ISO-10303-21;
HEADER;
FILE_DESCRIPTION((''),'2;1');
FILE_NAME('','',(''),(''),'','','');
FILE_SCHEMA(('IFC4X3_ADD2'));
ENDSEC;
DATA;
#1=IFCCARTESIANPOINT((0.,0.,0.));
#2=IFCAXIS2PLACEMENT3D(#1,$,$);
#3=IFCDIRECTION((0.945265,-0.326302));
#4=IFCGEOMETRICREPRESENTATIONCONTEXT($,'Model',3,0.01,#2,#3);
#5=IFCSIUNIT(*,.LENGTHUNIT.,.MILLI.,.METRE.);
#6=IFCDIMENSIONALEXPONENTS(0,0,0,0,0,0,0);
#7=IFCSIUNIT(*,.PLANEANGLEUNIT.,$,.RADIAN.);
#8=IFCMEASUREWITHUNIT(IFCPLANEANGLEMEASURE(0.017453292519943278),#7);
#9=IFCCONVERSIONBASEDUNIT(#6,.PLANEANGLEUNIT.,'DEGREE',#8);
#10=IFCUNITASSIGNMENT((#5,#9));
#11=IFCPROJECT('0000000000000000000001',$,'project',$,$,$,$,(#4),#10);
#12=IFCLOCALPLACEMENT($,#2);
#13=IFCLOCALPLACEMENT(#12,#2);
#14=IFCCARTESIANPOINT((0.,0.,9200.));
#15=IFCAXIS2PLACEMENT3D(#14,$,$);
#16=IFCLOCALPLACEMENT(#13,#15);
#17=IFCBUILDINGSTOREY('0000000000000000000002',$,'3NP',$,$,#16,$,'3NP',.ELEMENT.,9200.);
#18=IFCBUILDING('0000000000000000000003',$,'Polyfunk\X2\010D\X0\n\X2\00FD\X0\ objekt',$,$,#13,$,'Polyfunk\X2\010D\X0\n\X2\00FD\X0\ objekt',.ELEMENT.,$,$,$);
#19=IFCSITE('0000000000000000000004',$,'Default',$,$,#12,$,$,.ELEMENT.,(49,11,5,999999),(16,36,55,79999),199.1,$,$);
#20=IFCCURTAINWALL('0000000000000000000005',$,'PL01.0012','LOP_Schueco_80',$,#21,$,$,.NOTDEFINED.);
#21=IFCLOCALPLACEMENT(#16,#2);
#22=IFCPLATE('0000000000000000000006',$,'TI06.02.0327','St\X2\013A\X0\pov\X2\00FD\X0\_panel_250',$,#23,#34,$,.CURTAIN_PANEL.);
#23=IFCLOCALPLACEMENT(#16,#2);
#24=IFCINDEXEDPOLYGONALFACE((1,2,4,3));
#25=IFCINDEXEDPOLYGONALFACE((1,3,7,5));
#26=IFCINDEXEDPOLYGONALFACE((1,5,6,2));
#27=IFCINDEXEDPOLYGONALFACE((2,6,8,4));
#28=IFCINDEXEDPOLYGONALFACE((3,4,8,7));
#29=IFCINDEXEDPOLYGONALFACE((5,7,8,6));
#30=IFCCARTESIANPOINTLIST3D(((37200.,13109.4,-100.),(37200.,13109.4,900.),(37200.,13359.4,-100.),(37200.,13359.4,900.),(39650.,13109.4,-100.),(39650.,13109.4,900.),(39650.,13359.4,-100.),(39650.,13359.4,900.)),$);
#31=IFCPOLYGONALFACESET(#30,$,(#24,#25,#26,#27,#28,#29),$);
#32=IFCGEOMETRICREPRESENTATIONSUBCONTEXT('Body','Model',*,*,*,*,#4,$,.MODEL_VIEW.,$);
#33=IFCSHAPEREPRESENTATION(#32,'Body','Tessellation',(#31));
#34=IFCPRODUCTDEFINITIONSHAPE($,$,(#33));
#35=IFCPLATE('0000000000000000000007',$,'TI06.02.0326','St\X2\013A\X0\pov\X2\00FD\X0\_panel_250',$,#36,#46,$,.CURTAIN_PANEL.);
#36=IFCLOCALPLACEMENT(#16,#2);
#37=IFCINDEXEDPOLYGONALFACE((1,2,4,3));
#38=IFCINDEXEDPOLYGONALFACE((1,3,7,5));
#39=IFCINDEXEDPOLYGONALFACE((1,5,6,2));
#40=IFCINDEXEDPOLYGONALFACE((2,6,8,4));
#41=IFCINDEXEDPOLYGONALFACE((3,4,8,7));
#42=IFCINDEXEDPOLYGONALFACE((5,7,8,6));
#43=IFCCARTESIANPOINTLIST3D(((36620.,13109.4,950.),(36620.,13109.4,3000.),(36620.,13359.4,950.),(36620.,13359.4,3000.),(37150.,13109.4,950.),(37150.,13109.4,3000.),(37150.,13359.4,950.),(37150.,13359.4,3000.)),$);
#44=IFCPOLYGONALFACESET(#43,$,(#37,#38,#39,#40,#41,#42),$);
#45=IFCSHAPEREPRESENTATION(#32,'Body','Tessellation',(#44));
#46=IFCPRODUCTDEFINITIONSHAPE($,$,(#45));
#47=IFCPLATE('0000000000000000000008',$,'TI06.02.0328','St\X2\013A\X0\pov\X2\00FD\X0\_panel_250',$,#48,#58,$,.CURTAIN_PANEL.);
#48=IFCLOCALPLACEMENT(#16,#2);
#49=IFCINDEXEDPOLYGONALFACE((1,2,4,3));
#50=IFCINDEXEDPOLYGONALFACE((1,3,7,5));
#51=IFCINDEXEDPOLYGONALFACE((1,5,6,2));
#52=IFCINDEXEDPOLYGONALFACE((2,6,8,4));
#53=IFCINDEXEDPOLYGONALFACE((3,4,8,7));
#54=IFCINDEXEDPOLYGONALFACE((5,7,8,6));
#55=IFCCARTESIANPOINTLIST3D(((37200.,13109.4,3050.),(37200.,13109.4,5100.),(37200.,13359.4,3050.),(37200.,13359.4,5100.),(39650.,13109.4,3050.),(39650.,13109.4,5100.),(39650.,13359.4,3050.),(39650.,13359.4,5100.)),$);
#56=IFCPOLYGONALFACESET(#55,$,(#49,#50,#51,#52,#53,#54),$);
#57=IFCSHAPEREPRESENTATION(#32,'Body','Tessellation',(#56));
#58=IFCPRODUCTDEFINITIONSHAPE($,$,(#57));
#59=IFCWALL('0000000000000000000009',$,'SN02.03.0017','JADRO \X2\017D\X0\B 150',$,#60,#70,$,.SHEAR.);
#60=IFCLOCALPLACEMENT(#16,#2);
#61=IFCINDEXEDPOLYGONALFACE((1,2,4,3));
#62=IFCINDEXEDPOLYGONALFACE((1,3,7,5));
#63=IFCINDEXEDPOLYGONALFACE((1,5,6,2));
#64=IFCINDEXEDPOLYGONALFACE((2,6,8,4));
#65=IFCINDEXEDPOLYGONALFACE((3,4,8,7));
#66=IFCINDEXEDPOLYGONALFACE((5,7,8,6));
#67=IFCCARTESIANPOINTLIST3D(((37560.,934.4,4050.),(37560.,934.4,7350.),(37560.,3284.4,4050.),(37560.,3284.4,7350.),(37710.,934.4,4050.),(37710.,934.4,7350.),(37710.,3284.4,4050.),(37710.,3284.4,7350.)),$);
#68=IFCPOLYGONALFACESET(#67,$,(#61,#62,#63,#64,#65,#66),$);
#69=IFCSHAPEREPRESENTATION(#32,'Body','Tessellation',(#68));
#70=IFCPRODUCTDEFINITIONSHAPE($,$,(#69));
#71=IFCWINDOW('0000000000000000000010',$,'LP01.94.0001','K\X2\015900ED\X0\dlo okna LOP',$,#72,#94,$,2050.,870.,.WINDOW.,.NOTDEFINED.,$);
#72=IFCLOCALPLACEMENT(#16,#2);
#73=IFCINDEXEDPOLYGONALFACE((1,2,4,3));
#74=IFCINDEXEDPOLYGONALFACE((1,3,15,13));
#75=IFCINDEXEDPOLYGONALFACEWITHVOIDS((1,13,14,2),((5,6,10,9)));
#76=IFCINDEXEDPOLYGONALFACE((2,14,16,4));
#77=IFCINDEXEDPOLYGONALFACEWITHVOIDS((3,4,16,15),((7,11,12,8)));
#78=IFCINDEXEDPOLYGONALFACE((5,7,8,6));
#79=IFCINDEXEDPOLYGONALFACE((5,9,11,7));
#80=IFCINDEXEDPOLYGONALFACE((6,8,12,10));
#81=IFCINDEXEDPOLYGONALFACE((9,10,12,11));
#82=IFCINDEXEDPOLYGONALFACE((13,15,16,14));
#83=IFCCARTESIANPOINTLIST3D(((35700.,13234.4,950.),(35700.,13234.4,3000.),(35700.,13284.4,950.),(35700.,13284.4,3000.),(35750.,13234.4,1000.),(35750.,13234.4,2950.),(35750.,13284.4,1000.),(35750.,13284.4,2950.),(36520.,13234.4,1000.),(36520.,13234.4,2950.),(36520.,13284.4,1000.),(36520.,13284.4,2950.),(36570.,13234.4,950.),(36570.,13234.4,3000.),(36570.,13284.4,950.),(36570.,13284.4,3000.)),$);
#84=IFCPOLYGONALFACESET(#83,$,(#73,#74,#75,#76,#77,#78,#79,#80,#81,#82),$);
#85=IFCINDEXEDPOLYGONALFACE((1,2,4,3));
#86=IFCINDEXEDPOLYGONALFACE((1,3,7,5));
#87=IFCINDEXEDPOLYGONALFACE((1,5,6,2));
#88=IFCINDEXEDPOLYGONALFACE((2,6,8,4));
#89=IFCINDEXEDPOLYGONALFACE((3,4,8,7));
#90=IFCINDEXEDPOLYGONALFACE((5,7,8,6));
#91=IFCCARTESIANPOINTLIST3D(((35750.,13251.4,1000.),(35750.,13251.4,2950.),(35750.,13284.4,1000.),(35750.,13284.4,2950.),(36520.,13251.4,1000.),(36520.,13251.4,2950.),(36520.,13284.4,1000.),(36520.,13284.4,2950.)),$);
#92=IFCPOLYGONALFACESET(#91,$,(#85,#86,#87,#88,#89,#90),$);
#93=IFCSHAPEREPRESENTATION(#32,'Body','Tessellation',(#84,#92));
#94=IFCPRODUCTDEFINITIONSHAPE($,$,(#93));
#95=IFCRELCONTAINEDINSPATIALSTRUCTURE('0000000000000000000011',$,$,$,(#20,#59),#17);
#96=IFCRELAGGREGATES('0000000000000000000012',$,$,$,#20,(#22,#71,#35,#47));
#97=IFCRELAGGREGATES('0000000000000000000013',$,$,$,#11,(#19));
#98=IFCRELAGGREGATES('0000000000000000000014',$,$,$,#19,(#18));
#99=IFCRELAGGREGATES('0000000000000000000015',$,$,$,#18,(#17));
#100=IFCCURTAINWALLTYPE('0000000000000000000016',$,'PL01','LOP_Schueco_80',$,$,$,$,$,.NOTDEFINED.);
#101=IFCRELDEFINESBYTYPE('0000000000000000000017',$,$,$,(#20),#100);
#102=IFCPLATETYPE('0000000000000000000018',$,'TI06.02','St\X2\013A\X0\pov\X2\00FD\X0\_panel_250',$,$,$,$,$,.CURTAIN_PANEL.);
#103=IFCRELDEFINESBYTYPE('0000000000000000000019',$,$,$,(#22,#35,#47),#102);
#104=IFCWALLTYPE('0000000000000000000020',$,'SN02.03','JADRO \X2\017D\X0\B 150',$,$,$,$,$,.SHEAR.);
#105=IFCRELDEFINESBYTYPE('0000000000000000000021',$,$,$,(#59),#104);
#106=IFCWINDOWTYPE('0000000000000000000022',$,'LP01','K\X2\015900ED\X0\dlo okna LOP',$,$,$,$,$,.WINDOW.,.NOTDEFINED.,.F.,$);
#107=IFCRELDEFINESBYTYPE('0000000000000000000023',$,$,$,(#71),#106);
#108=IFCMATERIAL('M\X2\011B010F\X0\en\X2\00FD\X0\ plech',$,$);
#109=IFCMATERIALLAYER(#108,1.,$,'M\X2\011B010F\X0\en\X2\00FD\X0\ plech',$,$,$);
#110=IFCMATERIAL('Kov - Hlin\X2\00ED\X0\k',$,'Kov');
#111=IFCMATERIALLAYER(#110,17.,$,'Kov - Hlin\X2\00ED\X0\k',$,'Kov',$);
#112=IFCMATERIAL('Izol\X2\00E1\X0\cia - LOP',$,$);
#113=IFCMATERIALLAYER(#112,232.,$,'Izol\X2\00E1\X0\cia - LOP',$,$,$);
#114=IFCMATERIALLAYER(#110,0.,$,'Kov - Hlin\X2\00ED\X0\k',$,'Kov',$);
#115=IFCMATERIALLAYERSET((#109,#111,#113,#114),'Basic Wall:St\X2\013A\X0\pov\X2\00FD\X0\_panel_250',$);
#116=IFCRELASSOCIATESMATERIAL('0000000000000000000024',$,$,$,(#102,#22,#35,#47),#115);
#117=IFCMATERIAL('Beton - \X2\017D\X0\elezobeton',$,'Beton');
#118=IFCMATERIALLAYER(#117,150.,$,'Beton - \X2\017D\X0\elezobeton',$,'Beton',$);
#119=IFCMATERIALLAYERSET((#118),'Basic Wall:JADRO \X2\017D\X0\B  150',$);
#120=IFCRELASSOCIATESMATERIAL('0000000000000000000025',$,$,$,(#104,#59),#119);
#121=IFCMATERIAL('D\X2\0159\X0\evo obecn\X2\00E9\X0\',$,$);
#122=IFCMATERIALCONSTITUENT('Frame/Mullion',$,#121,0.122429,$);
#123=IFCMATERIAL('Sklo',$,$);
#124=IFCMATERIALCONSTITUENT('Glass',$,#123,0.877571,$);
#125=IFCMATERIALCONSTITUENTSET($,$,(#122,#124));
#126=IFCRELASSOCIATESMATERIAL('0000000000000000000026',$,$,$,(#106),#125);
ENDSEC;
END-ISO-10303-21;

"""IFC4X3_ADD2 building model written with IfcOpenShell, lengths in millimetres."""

from ifc_helpers import new_model, entity, si_unit, converted_unit, direction, frame, frame_2d, origin, origin_2d_with_axis, place, context, subcontext, project, spatial, polyline, rectangle, outline, extrude, source, transform, mapped, material, layer, layer_set, layer_usage, constituent, constituent_set, type_object, type_shapes, element, aggregate, save


model = new_model("IFC4X3_ADD2")

# Units and contexts
model_context = context("Model", 3, precision=0.01, world=origin(), true_north=direction((0.945265, -0.326302)))
body_context = subcontext(model_context, "Body", "Model", "MODEL_VIEW")
ifc_project = project(units=[si_unit("LENGTHUNIT", "METRE", prefix="MILLI"), converted_unit("PLANEANGLEUNIT", "DEGREE", entity("IfcPlaneAngleMeasure", 0.017453292519943278), si_unit("PLANEANGLEUNIT", "RADIAN"), dimensions=[0, 0, 0, 0, 0, 0, 0])], contexts=[model_context])

# Site, building, storey
site_placement = place(None, origin())
site = spatial("IfcSite", under=ifc_project, at=site_placement, Name="Default", CompositionType="ELEMENT", RefLatitude=(49, 11, 5, 999999), RefLongitude=(16, 36, 55, 79999), RefElevation=199.1)
building_placement = place(site_placement, origin())
building = spatial("IfcBuilding", under=site, at=building_placement, Name="Polyfunkčný objekt", LongName="Polyfunkčný objekt", CompositionType="ELEMENT")
storey_placement = place(building_placement, frame((0.0, 0.0, 9200.0)))
storey = spatial("IfcBuildingStorey", under=building, at=storey_placement, Name="3NP", LongName="3NP", CompositionType="ELEMENT", Elevation=9200.0)

# Curtain wall, plates
curtain_wall_type = type_object("IfcCurtainWallType", Name="PL01", Description="LOP_Schueco_80", PredefinedType="NOTDEFINED")
curtain_wall_placement = place(storey_placement, frame((0.0, 0.0, -9200.0)))
curtain_wall = element("IfcCurtainWall", 1, at=curtain_wall_placement, inside=storey, type_object=curtain_wall_type, Name="PL01.0012", Description="LOP_Schueco_80", PredefinedType="NOTDEFINED")
ifc_material_1 = material(Name="Měďený plech")
ifc_layer_1 = layer(ifc_material_1, 1.0, Name="Měďený plech")
ifc_material_2 = material(Name="Kov - Hliník", Category="Kov")
ifc_layer_2 = layer(ifc_material_2, 17.0, Name="Kov - Hliník", Category="Kov")
ifc_material_3 = material(Name="Izolácia - LOP")
ifc_layer_3 = layer(ifc_material_3, 232.0, Name="Izolácia - LOP")
ifc_layer_4 = layer(ifc_material_2, 0.0, Name="Kov - Hliník", Category="Kov")
ifc_layer_set_1 = layer_set([ifc_layer_1, ifc_layer_2, ifc_layer_3, ifc_layer_4], Name="Basic Wall:Stĺpový_panel_250")
ifc_layer_usage_1 = layer_usage(ifc_layer_set_1, "AXIS2", "NEGATIVE", 125.0)
plate_type = type_object("IfcPlateType", Name="TI06.02", Description="Stĺpový_panel_250", PredefinedType="CURTAIN_PANEL", material=ifc_layer_set_1)
plate_1_placement = place(storey_placement, frame((37200.0, 13234.4, -100.0)))
plate_1 = element("IfcPlate", 2, at=plate_1_placement, type_object=plate_type, material=ifc_layer_usage_1, Name="TI06.02.0327", Description="Stĺpový_panel_250", PredefinedType="CURTAIN_PANEL", context=body_context, shape_type="SweptSolid", body=[
    extrude(rectangle(XDim=250.0, YDim=2450.0, at=frame_2d((0.0, 0.0), x_axis=(1.0, 0.0))), frame((1225.0, 0.0, 0.0), z_axis=(0.0, 0.0, 1.0), x_axis=(0.0, 1.0, 0.0)), (0.0, 0.0, 1.0), 1000.0),
])
ifc_layer_usage_2 = layer_usage(ifc_layer_set_1, "AXIS2", "NEGATIVE", 125.0)
plate_2_placement = place(storey_placement, frame((36620.0, 13234.4, 950.0)))
plate_2 = element("IfcPlate", 3, at=plate_2_placement, type_object=plate_type, material=ifc_layer_usage_2, Name="TI06.02.0326", Description="Stĺpový_panel_250", PredefinedType="CURTAIN_PANEL", context=body_context, shape_type="SweptSolid", body=[
    extrude(rectangle(XDim=250.0, YDim=530.0, at=frame_2d((0.0, 0.0), x_axis=(1.0, 0.0))), frame((265.0, 0.0, 0.0), z_axis=(0.0, 0.0, 1.0), x_axis=(0.0, 1.0, 0.0)), (0.0, 0.0, 1.0), 2050.0),
])
ifc_layer_usage_3 = layer_usage(ifc_layer_set_1, "AXIS2", "NEGATIVE", 125.0)
plate_3_placement = place(storey_placement, frame((37200.0, 13234.4, 3050.0)))
plate_3 = element("IfcPlate", 4, at=plate_3_placement, type_object=plate_type, material=ifc_layer_usage_3, Name="TI06.02.0328", Description="Stĺpový_panel_250", PredefinedType="CURTAIN_PANEL", context=body_context, shape_type="SweptSolid", body=[
    extrude(rectangle(XDim=250.0, YDim=2450.0, at=frame_2d((0.0, 0.0), x_axis=(1.0, 0.0))), frame((1225.0, 0.0, 0.0), z_axis=(0.0, 0.0, 1.0), x_axis=(0.0, 1.0, 0.0)), (0.0, 0.0, 1.0), 2050.0),
])

# Wall
ifc_material_4 = material(Name="Beton - Železobeton", Category="Beton")
ifc_layer_5 = layer(ifc_material_4, 150.0, Name="Beton - Železobeton", Category="Beton")
ifc_layer_set_2 = layer_set([ifc_layer_5], Name="Basic Wall:JADRO ŽB  150")
wall_type = type_object("IfcWallType", Name="SN02.03", Description="JADRO ŽB 150", PredefinedType="SHEAR", material=ifc_layer_set_2)
wall_placement = place(storey_placement, frame((37635.0, 3284.4, 4050.0), z_axis=(0.0, 0.0, 1.0), x_axis=(0.0, -1.0, 0.0)))
element("IfcWall", 5, at=wall_placement, inside=storey, type_object=wall_type, material=ifc_layer_set_2, Name="SN02.03.0017", Description="JADRO ŽB 150", PredefinedType="SHEAR", context=body_context, shape_type="SweptSolid", body=[
    extrude(rectangle(XDim=2350.0, YDim=150.0, at=frame_2d((1175.0, 0.0), x_axis=(-1.0, 0.0))), origin(), (0.0, 0.0, 1.0), 3300.0),
])

# Window
ifc_material_5 = material(Name="Dřevo obecné")
ifc_constituent_1 = constituent(ifc_material_5, Name="Frame/Mullion", fraction=0.122429)
ifc_material_6 = material(Name="Sklo")
ifc_constituent_2 = constituent(ifc_material_6, Name="Glass", fraction=0.877571)
ifc_constituent_set = constituent_set(constituents=[ifc_constituent_1, ifc_constituent_2])
window_type = type_object("IfcWindowType", Name="LP01", Description="Křídlo okna LOP", ParameterTakesPrecedence=False, PartitioningType="NOTDEFINED", PredefinedType="WINDOW", material=ifc_constituent_set)
shared_shape_1 = source(origin(), body_context, "Body", "SweptSolid", [
    extrude(outline(polyline([(-1025.0, -435.0), (1025.0, -435.0), (1025.0, 435.0), (-1025.0, 435.0), (-1025.0, -435.0)]), holes=[polyline([(-975.0, -385.0), (-975.0, 385.0), (975.0, 385.0), (975.0, -385.0), (-975.0, -385.0)])]), frame((0.0, 0.0, 1025.0), z_axis=(0.0, 1.0, 0.0), x_axis=(0.0, 0.0, -1.0)), (0.0, 0.0, 1.0), 50.0),
    extrude(rectangle(XDim=33.0, YDim=770.0, at=origin_2d_with_axis()), frame((0.0, 33.5, 50.0), z_axis=(0.0, 0.0, 1.0), x_axis=(0.0, -1.0, 0.0)), (0.0, 0.0, 1.0), 1950.0),
])
type_shapes(window_type, [shared_shape_1])
window_placement = place(curtain_wall_placement, frame((36135.0, 13234.4, 10150.0)))
window = element("IfcWindow", 6, at=window_placement, type_object=window_type, Name="LP01.94.0001", Description="Křídlo okna LOP", OverallHeight=2050.0, OverallWidth=870.0, PartitioningType="NOTDEFINED", PredefinedType="WINDOW", context=body_context, shape_type="MappedRepresentation", body=[
    mapped(shared_shape_1, transform((0.0, 0.0, 0.0), scale=1.0)),
])
aggregate(curtain_wall, [plate_1, window, plate_2, plate_3])

save(model, "model.ifc")
